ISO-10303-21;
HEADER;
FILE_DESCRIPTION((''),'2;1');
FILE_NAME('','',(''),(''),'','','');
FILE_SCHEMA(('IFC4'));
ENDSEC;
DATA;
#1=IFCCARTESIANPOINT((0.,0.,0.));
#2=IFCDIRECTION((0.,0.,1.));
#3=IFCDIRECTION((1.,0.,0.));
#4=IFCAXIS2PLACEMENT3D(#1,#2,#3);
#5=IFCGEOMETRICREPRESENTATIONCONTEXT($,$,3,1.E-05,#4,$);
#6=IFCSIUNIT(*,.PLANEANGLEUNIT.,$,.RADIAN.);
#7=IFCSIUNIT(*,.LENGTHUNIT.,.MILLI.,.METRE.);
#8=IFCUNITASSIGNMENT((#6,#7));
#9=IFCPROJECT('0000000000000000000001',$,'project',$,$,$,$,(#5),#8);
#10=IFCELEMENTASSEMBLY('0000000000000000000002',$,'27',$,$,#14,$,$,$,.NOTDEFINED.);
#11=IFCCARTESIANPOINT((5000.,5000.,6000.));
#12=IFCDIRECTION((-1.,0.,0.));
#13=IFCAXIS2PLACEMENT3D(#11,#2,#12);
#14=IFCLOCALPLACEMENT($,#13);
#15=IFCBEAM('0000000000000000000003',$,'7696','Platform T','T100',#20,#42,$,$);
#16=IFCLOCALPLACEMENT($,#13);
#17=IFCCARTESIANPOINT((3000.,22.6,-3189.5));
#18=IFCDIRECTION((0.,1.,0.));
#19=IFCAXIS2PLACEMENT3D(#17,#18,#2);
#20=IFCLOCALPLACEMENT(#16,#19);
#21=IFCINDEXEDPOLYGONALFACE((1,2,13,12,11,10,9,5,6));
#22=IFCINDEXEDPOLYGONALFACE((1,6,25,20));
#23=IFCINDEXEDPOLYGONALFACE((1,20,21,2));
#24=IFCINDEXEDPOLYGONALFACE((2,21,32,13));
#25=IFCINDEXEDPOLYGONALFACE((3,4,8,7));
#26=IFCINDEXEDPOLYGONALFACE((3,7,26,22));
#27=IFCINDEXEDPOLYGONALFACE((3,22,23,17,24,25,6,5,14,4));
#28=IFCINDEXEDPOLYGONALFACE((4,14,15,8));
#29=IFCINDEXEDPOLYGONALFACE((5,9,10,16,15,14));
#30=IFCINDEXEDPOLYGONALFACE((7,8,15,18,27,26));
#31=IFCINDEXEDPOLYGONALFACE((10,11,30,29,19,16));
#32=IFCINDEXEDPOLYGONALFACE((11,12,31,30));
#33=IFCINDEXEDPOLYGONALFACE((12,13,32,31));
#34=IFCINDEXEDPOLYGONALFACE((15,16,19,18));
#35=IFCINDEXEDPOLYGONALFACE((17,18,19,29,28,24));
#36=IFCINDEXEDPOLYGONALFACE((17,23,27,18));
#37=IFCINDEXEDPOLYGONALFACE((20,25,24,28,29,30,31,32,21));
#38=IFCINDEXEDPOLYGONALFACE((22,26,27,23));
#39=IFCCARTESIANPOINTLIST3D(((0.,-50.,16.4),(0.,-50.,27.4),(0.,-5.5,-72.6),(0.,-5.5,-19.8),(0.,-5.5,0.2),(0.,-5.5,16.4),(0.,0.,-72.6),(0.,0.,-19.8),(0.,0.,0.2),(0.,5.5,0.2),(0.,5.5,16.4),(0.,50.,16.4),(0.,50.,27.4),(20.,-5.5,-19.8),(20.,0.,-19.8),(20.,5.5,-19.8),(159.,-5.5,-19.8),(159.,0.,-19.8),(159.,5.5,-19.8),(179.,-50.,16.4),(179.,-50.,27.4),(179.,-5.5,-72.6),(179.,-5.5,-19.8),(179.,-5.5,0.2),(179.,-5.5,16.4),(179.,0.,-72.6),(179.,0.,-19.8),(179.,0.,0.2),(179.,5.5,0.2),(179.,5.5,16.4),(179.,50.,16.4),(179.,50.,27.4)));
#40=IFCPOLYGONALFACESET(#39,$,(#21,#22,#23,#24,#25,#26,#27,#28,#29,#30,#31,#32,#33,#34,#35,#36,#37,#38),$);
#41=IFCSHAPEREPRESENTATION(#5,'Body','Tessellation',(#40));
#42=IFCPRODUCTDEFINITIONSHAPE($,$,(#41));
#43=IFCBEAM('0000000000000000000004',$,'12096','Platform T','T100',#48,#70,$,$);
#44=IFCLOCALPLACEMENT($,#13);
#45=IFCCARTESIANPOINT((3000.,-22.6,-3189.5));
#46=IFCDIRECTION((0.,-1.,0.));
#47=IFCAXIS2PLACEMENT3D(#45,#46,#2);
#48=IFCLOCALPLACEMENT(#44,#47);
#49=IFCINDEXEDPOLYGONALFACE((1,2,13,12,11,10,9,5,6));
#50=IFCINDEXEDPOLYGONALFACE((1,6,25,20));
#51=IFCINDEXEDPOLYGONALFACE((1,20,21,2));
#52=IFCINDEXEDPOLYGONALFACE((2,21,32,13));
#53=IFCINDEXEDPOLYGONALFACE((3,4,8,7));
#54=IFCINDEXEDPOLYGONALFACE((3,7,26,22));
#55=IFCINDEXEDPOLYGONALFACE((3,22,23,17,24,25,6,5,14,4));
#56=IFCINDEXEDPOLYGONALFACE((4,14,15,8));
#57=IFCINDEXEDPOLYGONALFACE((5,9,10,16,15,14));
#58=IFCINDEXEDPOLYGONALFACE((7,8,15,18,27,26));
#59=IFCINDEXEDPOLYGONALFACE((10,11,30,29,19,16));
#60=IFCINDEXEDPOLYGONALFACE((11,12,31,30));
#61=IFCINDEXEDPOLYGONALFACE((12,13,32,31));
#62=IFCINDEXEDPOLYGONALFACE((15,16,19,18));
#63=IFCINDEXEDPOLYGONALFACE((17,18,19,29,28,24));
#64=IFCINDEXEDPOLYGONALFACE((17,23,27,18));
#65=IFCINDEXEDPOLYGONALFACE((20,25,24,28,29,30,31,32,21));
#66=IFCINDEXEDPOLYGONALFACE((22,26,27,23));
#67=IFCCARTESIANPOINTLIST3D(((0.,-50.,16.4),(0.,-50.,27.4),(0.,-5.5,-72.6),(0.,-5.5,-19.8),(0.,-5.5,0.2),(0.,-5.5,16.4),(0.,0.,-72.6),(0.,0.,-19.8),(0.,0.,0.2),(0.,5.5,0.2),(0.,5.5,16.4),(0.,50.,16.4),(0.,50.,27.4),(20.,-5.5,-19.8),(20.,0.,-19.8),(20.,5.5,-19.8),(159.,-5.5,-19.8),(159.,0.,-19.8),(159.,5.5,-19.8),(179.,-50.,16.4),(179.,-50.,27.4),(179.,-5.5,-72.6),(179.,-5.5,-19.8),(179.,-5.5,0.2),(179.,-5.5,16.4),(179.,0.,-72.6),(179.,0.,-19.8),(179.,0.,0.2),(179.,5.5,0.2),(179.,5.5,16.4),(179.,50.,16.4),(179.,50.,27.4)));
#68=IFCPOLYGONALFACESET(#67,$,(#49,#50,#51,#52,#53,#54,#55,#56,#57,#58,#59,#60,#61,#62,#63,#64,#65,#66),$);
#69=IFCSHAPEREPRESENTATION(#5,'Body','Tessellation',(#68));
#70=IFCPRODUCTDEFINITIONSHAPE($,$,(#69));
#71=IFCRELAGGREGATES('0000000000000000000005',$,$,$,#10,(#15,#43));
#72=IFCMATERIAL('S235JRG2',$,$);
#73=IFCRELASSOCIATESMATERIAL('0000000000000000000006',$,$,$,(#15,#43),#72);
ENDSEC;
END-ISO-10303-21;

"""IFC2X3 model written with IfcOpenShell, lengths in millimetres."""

from ifc_helpers import new_model, si_unit, point, frame, origin_with_axes, place, context, project, polyline, line_curve, trimmed, segment, composite_curve, outline, extrude, material, element, aggregate, save


model = new_model("IFC2X3")

# Units and contexts
context_of_model = context(None, 3, precision=1e-05, world=origin_with_axes())
ifc_project = project(units=[si_unit("PLANEANGLEUNIT", "RADIAN"), si_unit("LENGTHUNIT", "METRE", prefix="MILLI")], contexts=[context_of_model])

# Element assembly, beams, openings
assembly_1_placement = place(None, frame((5000.0, 5000.0, 6000.0), z_axis=(0.0, 0.0, 1.0), x_axis=(-1.0, 0.0, 0.0)))
assembly_1 = element("IfcElementAssembly", 1, at=assembly_1_placement, Name="27", PredefinedType="NOTDEFINED")
ifc_material = material(Name="S235JRG2")
placement_1 = place(None, frame((5000.0, 5000.0, 6000.0), z_axis=(0.0, 0.0, 1.0), x_axis=(-1.0, 0.0, 0.0)))
beam_1_placement = place(placement_1, frame((3000.0, 22.6, -3189.5), z_axis=(0.0, 1.0, 0.0), x_axis=(0.0, 0.0, 1.0)))
beam_1 = element("IfcBeam", 2, at=beam_1_placement, material=ifc_material, Name="7696", Description="Platform T", ObjectType="T100", context=context_of_model, shape_type="SweptSolid", body=[
    extrude(outline(polyline([(5.5, -72.6), (5.5, 16.4), (50.0, 16.4), (50.0, 27.4), (-50.0, 27.4), (-50.0, 16.4), (-5.5, 16.4), (-5.5, -72.6), (5.5, -72.6), (5.5, -72.6)])), frame((0.0, 0.0, 0.0), z_axis=(1.0, 0.0, 0.0), x_axis=(0.0, 1.0, 0.0)), (0.0, 0.0, 1.0), 179.0),
])
opening_1_placement = place(beam_1_placement, frame((179.0, 0.0, -72.6), z_axis=(0.0, 1.0, 0.0), x_axis=(0.0, 0.0, 1.0)))
element("IfcOpeningElement", 3, at=opening_1_placement, cuts=beam_1, ObjectType="Recess", context=context_of_model, shape_type="SweptSolid", body=[
    extrude(outline(composite_curve([segment(trimmed(line_curve((0.0, 0.0), (0.0, -1.0, 0.0), 179.0), [point((0.0, 0.0))], [point((0.0, -179.0))], True, "CARTESIAN"), True, "CONTINUOUS"), segment(trimmed(line_curve((0.0, -179.0), (1.0, 0.0, 0.0), 52.8), [point((0.0, -179.0))], [point((52.8, -179.0))], True, "CARTESIAN"), True, "CONTINUOUS"), segment(trimmed(line_curve((52.8, -179.0), (0.0, 1.0, 0.0), 179.0), [point((52.8, -179.0))], [point((52.8, 0.0))], True, "CARTESIAN"), True, "CONTINUOUS"), segment(trimmed(line_curve((52.8, 0.0), (-1.0, 0.0, 0.0), 52.8), [point((52.8, 0.0))], [point((0.0, 0.0))], True, "CARTESIAN"), True, "CONTINUOUS")], self_intersect=False)), origin_with_axes(), (0.0, 0.0, 1.0), 100.0),
])
opening_2_placement = place(beam_1_placement, frame((179.0, 0.0, -19.8), z_axis=(0.0, 1.0, 0.0), x_axis=(0.0, 0.0, 1.0)))
element("IfcOpeningElement", 4, at=opening_2_placement, cuts=beam_1, context=context_of_model, shape_type="SweptSolid", body=[
    extrude(outline(composite_curve([segment(trimmed(line_curve((0.0, 0.0), (1.0, 0.0, 0.0), 20.0), [point((0.0, 0.0))], [point((20.0, 0.0))], True, "CARTESIAN"), True, "CONTINUOUS"), segment(trimmed(line_curve((20.0, 0.0), (-0.707107, -0.707107, 0.0), 28.284271), [point((20.0, 0.0))], [point((0.0, -20.0))], True, "CARTESIAN"), True, "CONTINUOUS"), segment(trimmed(line_curve((0.0, -20.0), (0.0, 1.0, 0.0), 20.0), [point((0.0, -20.0))], [point((0.0, 0.0))], True, "CARTESIAN"), True, "CONTINUOUS")], self_intersect=False)), origin_with_axes(), (0.0, 0.0, 1.0), 100.0),
])
opening_3_placement = place(beam_1_placement, frame((179.0, 0.0, -19.8), z_axis=(0.0, -1.0, 0.0), x_axis=(0.0, 0.0, -1.0)))
element("IfcOpeningElement", 5, at=opening_3_placement, cuts=beam_1, context=context_of_model, shape_type="SweptSolid", body=[
    extrude(outline(composite_curve([segment(trimmed(line_curve((0.0, 0.0), (-1.0, 0.0, 0.0), 20.0), [point((0.0, 0.0))], [point((-20.0, 0.0))], True, "CARTESIAN"), True, "CONTINUOUS"), segment(trimmed(line_curve((-20.0, 0.0), (0.707107, -0.707107, 0.0), 28.284271), [point((-20.0, 0.0))], [point((0.0, -20.0))], True, "CARTESIAN"), True, "CONTINUOUS"), segment(trimmed(line_curve((0.0, -20.0), (0.0, 1.0, 0.0), 20.0), [point((0.0, -20.0))], [point((0.0, 0.0))], True, "CARTESIAN"), True, "CONTINUOUS")], self_intersect=False)), origin_with_axes(), (0.0, 0.0, 1.0), 100.0),
])
opening_4_placement = place(beam_1_placement, frame((0.0, 0.0, -19.8), z_axis=(0.0, -1.0, 0.0), x_axis=(0.0, 0.0, -1.0)))
element("IfcOpeningElement", 6, at=opening_4_placement, cuts=beam_1, context=context_of_model, shape_type="SweptSolid", body=[
    extrude(outline(composite_curve([segment(trimmed(line_curve((0.0, 0.0), (-1.0, 0.0, 0.0), 20.0), [point((0.0, 0.0))], [point((-20.0, 0.0))], True, "CARTESIAN"), True, "CONTINUOUS"), segment(trimmed(line_curve((-20.0, 0.0), (0.707107, 0.707107, 0.0), 28.284271), [point((-20.0, 0.0))], [point((0.0, 20.0))], True, "CARTESIAN"), True, "CONTINUOUS"), segment(trimmed(line_curve((0.0, 20.0), (0.0, -1.0, 0.0), 20.0), [point((0.0, 20.0))], [point((0.0, 0.0))], True, "CARTESIAN"), True, "CONTINUOUS")], self_intersect=False)), origin_with_axes(), (0.0, 0.0, 1.0), 100.0),
])
opening_5_placement = place(beam_1_placement, frame((0.0, 0.0, -19.8), z_axis=(0.0, 1.0, 0.0), x_axis=(0.0, 0.0, 1.0)))
element("IfcOpeningElement", 7, at=opening_5_placement, cuts=beam_1, context=context_of_model, shape_type="SweptSolid", body=[
    extrude(outline(composite_curve([segment(trimmed(line_curve((0.0, 0.0), (1.0, 0.0, 0.0), 20.0), [point((0.0, 0.0))], [point((20.0, 0.0))], True, "CARTESIAN"), True, "CONTINUOUS"), segment(trimmed(line_curve((20.0, 0.0), (-0.707107, 0.707107, 0.0), 28.284271), [point((20.0, 0.0))], [point((0.0, 20.0))], True, "CARTESIAN"), True, "CONTINUOUS"), segment(trimmed(line_curve((0.0, 20.0), (0.0, -1.0, 0.0), 20.0), [point((0.0, 20.0))], [point((0.0, 0.0))], True, "CARTESIAN"), True, "CONTINUOUS")], self_intersect=False)), origin_with_axes(), (0.0, 0.0, 1.0), 100.0),
])
placement_2 = place(None, frame((5000.0, 5000.0, 6000.0), z_axis=(0.0, 0.0, 1.0), x_axis=(-1.0, 0.0, 0.0)))
beam_2_placement = place(placement_2, frame((3000.0, -22.6, -3189.5), z_axis=(0.0, -1.0, 0.0), x_axis=(0.0, 0.0, 1.0)))
beam_2 = element("IfcBeam", 8, at=beam_2_placement, material=ifc_material, Name="12096", Description="Platform T", ObjectType="T100", context=context_of_model, shape_type="SweptSolid", body=[
    extrude(outline(polyline([(5.5, -72.6), (5.5, 16.4), (50.0, 16.4), (50.0, 27.4), (-50.0, 27.4), (-50.0, 16.4), (-5.5, 16.4), (-5.5, -72.6), (5.5, -72.6), (5.5, -72.6)])), frame((0.0, 0.0, 0.0), z_axis=(1.0, 0.0, 0.0), x_axis=(0.0, 1.0, 0.0)), (0.0, 0.0, 1.0), 179.0),
])
opening_6_placement = place(beam_2_placement, frame((179.0, 0.0, -72.6), z_axis=(0.0, 1.0, 0.0), x_axis=(0.0, 0.0, 1.0)))
element("IfcOpeningElement", 9, at=opening_6_placement, cuts=beam_2, ObjectType="Recess", context=context_of_model, shape_type="SweptSolid", body=[
    extrude(outline(composite_curve([segment(trimmed(line_curve((0.0, 0.0), (0.0, -1.0, 0.0), 179.0), [point((0.0, 0.0))], [point((0.0, -179.0))], True, "CARTESIAN"), True, "CONTINUOUS"), segment(trimmed(line_curve((0.0, -179.0), (1.0, 0.0, 0.0), 52.8), [point((0.0, -179.0))], [point((52.8, -179.0))], True, "CARTESIAN"), True, "CONTINUOUS"), segment(trimmed(line_curve((52.8, -179.0), (0.0, 1.0, 0.0), 179.0), [point((52.8, -179.0))], [point((52.8, 0.0))], True, "CARTESIAN"), True, "CONTINUOUS"), segment(trimmed(line_curve((52.8, 0.0), (-1.0, 0.0, 0.0), 52.8), [point((52.8, 0.0))], [point((0.0, 0.0))], True, "CARTESIAN"), True, "CONTINUOUS")], self_intersect=False)), origin_with_axes(), (0.0, 0.0, 1.0), 100.0),
])
opening_7_placement = place(beam_2_placement, frame((179.0, 0.0, -19.8), z_axis=(0.0, 1.0, 0.0), x_axis=(0.0, 0.0, 1.0)))
element("IfcOpeningElement", 10, at=opening_7_placement, cuts=beam_2, context=context_of_model, shape_type="SweptSolid", body=[
    extrude(outline(composite_curve([segment(trimmed(line_curve((0.0, 0.0), (1.0, 0.0, 0.0), 20.0), [point((0.0, 0.0))], [point((20.0, 0.0))], True, "CARTESIAN"), True, "CONTINUOUS"), segment(trimmed(line_curve((20.0, 0.0), (-0.707107, -0.707107, 0.0), 28.284271), [point((20.0, 0.0))], [point((0.0, -20.0))], True, "CARTESIAN"), True, "CONTINUOUS"), segment(trimmed(line_curve((0.0, -20.0), (0.0, 1.0, 0.0), 20.0), [point((0.0, -20.0))], [point((0.0, 0.0))], True, "CARTESIAN"), True, "CONTINUOUS")], self_intersect=False)), origin_with_axes(), (0.0, 0.0, 1.0), 100.0),
])
opening_8_placement = place(beam_2_placement, frame((179.0, 0.0, -19.8), z_axis=(0.0, -1.0, 0.0), x_axis=(0.0, 0.0, -1.0)))
element("IfcOpeningElement", 11, at=opening_8_placement, cuts=beam_2, context=context_of_model, shape_type="SweptSolid", body=[
    extrude(outline(composite_curve([segment(trimmed(line_curve((0.0, 0.0), (-1.0, 0.0, 0.0), 20.0), [point((0.0, 0.0))], [point((-20.0, 0.0))], True, "CARTESIAN"), True, "CONTINUOUS"), segment(trimmed(line_curve((-20.0, 0.0), (0.707107, -0.707107, 0.0), 28.284271), [point((-20.0, 0.0))], [point((0.0, -20.0))], True, "CARTESIAN"), True, "CONTINUOUS"), segment(trimmed(line_curve((0.0, -20.0), (0.0, 1.0, 0.0), 20.0), [point((0.0, -20.0))], [point((0.0, 0.0))], True, "CARTESIAN"), True, "CONTINUOUS")], self_intersect=False)), origin_with_axes(), (0.0, 0.0, 1.0), 100.0),
])
opening_9_placement = place(beam_2_placement, frame((0.0, 0.0, -19.8), z_axis=(0.0, -1.0, 0.0), x_axis=(0.0, 0.0, -1.0)))
element("IfcOpeningElement", 12, at=opening_9_placement, cuts=beam_2, context=context_of_model, shape_type="SweptSolid", body=[
    extrude(outline(composite_curve([segment(trimmed(line_curve((0.0, 0.0), (-1.0, 0.0, 0.0), 20.0), [point((0.0, 0.0))], [point((-20.0, 0.0))], True, "CARTESIAN"), True, "CONTINUOUS"), segment(trimmed(line_curve((-20.0, 0.0), (0.707107, 0.707107, 0.0), 28.284271), [point((-20.0, 0.0))], [point((0.0, 20.0))], True, "CARTESIAN"), True, "CONTINUOUS"), segment(trimmed(line_curve((0.0, 20.0), (0.0, -1.0, 0.0), 20.0), [point((0.0, 20.0))], [point((0.0, 0.0))], True, "CARTESIAN"), True, "CONTINUOUS")], self_intersect=False)), origin_with_axes(), (0.0, 0.0, 1.0), 100.0),
])
opening_10_placement = place(beam_2_placement, frame((0.0, 0.0, -19.8), z_axis=(0.0, 1.0, 0.0), x_axis=(0.0, 0.0, 1.0)))
element("IfcOpeningElement", 13, at=opening_10_placement, cuts=beam_2, context=context_of_model, shape_type="SweptSolid", body=[
    extrude(outline(composite_curve([segment(trimmed(line_curve((0.0, 0.0), (1.0, 0.0, 0.0), 20.0), [point((0.0, 0.0))], [point((20.0, 0.0))], True, "CARTESIAN"), True, "CONTINUOUS"), segment(trimmed(line_curve((20.0, 0.0), (-0.707107, 0.707107, 0.0), 28.284271), [point((20.0, 0.0))], [point((0.0, 20.0))], True, "CARTESIAN"), True, "CONTINUOUS"), segment(trimmed(line_curve((0.0, 20.0), (0.0, -1.0, 0.0), 20.0), [point((0.0, 20.0))], [point((0.0, 0.0))], True, "CARTESIAN"), True, "CONTINUOUS")], self_intersect=False)), origin_with_axes(), (0.0, 0.0, 1.0), 100.0),
])
aggregate(assembly_1, [beam_1, beam_2])

save(model, "model.ifc")
